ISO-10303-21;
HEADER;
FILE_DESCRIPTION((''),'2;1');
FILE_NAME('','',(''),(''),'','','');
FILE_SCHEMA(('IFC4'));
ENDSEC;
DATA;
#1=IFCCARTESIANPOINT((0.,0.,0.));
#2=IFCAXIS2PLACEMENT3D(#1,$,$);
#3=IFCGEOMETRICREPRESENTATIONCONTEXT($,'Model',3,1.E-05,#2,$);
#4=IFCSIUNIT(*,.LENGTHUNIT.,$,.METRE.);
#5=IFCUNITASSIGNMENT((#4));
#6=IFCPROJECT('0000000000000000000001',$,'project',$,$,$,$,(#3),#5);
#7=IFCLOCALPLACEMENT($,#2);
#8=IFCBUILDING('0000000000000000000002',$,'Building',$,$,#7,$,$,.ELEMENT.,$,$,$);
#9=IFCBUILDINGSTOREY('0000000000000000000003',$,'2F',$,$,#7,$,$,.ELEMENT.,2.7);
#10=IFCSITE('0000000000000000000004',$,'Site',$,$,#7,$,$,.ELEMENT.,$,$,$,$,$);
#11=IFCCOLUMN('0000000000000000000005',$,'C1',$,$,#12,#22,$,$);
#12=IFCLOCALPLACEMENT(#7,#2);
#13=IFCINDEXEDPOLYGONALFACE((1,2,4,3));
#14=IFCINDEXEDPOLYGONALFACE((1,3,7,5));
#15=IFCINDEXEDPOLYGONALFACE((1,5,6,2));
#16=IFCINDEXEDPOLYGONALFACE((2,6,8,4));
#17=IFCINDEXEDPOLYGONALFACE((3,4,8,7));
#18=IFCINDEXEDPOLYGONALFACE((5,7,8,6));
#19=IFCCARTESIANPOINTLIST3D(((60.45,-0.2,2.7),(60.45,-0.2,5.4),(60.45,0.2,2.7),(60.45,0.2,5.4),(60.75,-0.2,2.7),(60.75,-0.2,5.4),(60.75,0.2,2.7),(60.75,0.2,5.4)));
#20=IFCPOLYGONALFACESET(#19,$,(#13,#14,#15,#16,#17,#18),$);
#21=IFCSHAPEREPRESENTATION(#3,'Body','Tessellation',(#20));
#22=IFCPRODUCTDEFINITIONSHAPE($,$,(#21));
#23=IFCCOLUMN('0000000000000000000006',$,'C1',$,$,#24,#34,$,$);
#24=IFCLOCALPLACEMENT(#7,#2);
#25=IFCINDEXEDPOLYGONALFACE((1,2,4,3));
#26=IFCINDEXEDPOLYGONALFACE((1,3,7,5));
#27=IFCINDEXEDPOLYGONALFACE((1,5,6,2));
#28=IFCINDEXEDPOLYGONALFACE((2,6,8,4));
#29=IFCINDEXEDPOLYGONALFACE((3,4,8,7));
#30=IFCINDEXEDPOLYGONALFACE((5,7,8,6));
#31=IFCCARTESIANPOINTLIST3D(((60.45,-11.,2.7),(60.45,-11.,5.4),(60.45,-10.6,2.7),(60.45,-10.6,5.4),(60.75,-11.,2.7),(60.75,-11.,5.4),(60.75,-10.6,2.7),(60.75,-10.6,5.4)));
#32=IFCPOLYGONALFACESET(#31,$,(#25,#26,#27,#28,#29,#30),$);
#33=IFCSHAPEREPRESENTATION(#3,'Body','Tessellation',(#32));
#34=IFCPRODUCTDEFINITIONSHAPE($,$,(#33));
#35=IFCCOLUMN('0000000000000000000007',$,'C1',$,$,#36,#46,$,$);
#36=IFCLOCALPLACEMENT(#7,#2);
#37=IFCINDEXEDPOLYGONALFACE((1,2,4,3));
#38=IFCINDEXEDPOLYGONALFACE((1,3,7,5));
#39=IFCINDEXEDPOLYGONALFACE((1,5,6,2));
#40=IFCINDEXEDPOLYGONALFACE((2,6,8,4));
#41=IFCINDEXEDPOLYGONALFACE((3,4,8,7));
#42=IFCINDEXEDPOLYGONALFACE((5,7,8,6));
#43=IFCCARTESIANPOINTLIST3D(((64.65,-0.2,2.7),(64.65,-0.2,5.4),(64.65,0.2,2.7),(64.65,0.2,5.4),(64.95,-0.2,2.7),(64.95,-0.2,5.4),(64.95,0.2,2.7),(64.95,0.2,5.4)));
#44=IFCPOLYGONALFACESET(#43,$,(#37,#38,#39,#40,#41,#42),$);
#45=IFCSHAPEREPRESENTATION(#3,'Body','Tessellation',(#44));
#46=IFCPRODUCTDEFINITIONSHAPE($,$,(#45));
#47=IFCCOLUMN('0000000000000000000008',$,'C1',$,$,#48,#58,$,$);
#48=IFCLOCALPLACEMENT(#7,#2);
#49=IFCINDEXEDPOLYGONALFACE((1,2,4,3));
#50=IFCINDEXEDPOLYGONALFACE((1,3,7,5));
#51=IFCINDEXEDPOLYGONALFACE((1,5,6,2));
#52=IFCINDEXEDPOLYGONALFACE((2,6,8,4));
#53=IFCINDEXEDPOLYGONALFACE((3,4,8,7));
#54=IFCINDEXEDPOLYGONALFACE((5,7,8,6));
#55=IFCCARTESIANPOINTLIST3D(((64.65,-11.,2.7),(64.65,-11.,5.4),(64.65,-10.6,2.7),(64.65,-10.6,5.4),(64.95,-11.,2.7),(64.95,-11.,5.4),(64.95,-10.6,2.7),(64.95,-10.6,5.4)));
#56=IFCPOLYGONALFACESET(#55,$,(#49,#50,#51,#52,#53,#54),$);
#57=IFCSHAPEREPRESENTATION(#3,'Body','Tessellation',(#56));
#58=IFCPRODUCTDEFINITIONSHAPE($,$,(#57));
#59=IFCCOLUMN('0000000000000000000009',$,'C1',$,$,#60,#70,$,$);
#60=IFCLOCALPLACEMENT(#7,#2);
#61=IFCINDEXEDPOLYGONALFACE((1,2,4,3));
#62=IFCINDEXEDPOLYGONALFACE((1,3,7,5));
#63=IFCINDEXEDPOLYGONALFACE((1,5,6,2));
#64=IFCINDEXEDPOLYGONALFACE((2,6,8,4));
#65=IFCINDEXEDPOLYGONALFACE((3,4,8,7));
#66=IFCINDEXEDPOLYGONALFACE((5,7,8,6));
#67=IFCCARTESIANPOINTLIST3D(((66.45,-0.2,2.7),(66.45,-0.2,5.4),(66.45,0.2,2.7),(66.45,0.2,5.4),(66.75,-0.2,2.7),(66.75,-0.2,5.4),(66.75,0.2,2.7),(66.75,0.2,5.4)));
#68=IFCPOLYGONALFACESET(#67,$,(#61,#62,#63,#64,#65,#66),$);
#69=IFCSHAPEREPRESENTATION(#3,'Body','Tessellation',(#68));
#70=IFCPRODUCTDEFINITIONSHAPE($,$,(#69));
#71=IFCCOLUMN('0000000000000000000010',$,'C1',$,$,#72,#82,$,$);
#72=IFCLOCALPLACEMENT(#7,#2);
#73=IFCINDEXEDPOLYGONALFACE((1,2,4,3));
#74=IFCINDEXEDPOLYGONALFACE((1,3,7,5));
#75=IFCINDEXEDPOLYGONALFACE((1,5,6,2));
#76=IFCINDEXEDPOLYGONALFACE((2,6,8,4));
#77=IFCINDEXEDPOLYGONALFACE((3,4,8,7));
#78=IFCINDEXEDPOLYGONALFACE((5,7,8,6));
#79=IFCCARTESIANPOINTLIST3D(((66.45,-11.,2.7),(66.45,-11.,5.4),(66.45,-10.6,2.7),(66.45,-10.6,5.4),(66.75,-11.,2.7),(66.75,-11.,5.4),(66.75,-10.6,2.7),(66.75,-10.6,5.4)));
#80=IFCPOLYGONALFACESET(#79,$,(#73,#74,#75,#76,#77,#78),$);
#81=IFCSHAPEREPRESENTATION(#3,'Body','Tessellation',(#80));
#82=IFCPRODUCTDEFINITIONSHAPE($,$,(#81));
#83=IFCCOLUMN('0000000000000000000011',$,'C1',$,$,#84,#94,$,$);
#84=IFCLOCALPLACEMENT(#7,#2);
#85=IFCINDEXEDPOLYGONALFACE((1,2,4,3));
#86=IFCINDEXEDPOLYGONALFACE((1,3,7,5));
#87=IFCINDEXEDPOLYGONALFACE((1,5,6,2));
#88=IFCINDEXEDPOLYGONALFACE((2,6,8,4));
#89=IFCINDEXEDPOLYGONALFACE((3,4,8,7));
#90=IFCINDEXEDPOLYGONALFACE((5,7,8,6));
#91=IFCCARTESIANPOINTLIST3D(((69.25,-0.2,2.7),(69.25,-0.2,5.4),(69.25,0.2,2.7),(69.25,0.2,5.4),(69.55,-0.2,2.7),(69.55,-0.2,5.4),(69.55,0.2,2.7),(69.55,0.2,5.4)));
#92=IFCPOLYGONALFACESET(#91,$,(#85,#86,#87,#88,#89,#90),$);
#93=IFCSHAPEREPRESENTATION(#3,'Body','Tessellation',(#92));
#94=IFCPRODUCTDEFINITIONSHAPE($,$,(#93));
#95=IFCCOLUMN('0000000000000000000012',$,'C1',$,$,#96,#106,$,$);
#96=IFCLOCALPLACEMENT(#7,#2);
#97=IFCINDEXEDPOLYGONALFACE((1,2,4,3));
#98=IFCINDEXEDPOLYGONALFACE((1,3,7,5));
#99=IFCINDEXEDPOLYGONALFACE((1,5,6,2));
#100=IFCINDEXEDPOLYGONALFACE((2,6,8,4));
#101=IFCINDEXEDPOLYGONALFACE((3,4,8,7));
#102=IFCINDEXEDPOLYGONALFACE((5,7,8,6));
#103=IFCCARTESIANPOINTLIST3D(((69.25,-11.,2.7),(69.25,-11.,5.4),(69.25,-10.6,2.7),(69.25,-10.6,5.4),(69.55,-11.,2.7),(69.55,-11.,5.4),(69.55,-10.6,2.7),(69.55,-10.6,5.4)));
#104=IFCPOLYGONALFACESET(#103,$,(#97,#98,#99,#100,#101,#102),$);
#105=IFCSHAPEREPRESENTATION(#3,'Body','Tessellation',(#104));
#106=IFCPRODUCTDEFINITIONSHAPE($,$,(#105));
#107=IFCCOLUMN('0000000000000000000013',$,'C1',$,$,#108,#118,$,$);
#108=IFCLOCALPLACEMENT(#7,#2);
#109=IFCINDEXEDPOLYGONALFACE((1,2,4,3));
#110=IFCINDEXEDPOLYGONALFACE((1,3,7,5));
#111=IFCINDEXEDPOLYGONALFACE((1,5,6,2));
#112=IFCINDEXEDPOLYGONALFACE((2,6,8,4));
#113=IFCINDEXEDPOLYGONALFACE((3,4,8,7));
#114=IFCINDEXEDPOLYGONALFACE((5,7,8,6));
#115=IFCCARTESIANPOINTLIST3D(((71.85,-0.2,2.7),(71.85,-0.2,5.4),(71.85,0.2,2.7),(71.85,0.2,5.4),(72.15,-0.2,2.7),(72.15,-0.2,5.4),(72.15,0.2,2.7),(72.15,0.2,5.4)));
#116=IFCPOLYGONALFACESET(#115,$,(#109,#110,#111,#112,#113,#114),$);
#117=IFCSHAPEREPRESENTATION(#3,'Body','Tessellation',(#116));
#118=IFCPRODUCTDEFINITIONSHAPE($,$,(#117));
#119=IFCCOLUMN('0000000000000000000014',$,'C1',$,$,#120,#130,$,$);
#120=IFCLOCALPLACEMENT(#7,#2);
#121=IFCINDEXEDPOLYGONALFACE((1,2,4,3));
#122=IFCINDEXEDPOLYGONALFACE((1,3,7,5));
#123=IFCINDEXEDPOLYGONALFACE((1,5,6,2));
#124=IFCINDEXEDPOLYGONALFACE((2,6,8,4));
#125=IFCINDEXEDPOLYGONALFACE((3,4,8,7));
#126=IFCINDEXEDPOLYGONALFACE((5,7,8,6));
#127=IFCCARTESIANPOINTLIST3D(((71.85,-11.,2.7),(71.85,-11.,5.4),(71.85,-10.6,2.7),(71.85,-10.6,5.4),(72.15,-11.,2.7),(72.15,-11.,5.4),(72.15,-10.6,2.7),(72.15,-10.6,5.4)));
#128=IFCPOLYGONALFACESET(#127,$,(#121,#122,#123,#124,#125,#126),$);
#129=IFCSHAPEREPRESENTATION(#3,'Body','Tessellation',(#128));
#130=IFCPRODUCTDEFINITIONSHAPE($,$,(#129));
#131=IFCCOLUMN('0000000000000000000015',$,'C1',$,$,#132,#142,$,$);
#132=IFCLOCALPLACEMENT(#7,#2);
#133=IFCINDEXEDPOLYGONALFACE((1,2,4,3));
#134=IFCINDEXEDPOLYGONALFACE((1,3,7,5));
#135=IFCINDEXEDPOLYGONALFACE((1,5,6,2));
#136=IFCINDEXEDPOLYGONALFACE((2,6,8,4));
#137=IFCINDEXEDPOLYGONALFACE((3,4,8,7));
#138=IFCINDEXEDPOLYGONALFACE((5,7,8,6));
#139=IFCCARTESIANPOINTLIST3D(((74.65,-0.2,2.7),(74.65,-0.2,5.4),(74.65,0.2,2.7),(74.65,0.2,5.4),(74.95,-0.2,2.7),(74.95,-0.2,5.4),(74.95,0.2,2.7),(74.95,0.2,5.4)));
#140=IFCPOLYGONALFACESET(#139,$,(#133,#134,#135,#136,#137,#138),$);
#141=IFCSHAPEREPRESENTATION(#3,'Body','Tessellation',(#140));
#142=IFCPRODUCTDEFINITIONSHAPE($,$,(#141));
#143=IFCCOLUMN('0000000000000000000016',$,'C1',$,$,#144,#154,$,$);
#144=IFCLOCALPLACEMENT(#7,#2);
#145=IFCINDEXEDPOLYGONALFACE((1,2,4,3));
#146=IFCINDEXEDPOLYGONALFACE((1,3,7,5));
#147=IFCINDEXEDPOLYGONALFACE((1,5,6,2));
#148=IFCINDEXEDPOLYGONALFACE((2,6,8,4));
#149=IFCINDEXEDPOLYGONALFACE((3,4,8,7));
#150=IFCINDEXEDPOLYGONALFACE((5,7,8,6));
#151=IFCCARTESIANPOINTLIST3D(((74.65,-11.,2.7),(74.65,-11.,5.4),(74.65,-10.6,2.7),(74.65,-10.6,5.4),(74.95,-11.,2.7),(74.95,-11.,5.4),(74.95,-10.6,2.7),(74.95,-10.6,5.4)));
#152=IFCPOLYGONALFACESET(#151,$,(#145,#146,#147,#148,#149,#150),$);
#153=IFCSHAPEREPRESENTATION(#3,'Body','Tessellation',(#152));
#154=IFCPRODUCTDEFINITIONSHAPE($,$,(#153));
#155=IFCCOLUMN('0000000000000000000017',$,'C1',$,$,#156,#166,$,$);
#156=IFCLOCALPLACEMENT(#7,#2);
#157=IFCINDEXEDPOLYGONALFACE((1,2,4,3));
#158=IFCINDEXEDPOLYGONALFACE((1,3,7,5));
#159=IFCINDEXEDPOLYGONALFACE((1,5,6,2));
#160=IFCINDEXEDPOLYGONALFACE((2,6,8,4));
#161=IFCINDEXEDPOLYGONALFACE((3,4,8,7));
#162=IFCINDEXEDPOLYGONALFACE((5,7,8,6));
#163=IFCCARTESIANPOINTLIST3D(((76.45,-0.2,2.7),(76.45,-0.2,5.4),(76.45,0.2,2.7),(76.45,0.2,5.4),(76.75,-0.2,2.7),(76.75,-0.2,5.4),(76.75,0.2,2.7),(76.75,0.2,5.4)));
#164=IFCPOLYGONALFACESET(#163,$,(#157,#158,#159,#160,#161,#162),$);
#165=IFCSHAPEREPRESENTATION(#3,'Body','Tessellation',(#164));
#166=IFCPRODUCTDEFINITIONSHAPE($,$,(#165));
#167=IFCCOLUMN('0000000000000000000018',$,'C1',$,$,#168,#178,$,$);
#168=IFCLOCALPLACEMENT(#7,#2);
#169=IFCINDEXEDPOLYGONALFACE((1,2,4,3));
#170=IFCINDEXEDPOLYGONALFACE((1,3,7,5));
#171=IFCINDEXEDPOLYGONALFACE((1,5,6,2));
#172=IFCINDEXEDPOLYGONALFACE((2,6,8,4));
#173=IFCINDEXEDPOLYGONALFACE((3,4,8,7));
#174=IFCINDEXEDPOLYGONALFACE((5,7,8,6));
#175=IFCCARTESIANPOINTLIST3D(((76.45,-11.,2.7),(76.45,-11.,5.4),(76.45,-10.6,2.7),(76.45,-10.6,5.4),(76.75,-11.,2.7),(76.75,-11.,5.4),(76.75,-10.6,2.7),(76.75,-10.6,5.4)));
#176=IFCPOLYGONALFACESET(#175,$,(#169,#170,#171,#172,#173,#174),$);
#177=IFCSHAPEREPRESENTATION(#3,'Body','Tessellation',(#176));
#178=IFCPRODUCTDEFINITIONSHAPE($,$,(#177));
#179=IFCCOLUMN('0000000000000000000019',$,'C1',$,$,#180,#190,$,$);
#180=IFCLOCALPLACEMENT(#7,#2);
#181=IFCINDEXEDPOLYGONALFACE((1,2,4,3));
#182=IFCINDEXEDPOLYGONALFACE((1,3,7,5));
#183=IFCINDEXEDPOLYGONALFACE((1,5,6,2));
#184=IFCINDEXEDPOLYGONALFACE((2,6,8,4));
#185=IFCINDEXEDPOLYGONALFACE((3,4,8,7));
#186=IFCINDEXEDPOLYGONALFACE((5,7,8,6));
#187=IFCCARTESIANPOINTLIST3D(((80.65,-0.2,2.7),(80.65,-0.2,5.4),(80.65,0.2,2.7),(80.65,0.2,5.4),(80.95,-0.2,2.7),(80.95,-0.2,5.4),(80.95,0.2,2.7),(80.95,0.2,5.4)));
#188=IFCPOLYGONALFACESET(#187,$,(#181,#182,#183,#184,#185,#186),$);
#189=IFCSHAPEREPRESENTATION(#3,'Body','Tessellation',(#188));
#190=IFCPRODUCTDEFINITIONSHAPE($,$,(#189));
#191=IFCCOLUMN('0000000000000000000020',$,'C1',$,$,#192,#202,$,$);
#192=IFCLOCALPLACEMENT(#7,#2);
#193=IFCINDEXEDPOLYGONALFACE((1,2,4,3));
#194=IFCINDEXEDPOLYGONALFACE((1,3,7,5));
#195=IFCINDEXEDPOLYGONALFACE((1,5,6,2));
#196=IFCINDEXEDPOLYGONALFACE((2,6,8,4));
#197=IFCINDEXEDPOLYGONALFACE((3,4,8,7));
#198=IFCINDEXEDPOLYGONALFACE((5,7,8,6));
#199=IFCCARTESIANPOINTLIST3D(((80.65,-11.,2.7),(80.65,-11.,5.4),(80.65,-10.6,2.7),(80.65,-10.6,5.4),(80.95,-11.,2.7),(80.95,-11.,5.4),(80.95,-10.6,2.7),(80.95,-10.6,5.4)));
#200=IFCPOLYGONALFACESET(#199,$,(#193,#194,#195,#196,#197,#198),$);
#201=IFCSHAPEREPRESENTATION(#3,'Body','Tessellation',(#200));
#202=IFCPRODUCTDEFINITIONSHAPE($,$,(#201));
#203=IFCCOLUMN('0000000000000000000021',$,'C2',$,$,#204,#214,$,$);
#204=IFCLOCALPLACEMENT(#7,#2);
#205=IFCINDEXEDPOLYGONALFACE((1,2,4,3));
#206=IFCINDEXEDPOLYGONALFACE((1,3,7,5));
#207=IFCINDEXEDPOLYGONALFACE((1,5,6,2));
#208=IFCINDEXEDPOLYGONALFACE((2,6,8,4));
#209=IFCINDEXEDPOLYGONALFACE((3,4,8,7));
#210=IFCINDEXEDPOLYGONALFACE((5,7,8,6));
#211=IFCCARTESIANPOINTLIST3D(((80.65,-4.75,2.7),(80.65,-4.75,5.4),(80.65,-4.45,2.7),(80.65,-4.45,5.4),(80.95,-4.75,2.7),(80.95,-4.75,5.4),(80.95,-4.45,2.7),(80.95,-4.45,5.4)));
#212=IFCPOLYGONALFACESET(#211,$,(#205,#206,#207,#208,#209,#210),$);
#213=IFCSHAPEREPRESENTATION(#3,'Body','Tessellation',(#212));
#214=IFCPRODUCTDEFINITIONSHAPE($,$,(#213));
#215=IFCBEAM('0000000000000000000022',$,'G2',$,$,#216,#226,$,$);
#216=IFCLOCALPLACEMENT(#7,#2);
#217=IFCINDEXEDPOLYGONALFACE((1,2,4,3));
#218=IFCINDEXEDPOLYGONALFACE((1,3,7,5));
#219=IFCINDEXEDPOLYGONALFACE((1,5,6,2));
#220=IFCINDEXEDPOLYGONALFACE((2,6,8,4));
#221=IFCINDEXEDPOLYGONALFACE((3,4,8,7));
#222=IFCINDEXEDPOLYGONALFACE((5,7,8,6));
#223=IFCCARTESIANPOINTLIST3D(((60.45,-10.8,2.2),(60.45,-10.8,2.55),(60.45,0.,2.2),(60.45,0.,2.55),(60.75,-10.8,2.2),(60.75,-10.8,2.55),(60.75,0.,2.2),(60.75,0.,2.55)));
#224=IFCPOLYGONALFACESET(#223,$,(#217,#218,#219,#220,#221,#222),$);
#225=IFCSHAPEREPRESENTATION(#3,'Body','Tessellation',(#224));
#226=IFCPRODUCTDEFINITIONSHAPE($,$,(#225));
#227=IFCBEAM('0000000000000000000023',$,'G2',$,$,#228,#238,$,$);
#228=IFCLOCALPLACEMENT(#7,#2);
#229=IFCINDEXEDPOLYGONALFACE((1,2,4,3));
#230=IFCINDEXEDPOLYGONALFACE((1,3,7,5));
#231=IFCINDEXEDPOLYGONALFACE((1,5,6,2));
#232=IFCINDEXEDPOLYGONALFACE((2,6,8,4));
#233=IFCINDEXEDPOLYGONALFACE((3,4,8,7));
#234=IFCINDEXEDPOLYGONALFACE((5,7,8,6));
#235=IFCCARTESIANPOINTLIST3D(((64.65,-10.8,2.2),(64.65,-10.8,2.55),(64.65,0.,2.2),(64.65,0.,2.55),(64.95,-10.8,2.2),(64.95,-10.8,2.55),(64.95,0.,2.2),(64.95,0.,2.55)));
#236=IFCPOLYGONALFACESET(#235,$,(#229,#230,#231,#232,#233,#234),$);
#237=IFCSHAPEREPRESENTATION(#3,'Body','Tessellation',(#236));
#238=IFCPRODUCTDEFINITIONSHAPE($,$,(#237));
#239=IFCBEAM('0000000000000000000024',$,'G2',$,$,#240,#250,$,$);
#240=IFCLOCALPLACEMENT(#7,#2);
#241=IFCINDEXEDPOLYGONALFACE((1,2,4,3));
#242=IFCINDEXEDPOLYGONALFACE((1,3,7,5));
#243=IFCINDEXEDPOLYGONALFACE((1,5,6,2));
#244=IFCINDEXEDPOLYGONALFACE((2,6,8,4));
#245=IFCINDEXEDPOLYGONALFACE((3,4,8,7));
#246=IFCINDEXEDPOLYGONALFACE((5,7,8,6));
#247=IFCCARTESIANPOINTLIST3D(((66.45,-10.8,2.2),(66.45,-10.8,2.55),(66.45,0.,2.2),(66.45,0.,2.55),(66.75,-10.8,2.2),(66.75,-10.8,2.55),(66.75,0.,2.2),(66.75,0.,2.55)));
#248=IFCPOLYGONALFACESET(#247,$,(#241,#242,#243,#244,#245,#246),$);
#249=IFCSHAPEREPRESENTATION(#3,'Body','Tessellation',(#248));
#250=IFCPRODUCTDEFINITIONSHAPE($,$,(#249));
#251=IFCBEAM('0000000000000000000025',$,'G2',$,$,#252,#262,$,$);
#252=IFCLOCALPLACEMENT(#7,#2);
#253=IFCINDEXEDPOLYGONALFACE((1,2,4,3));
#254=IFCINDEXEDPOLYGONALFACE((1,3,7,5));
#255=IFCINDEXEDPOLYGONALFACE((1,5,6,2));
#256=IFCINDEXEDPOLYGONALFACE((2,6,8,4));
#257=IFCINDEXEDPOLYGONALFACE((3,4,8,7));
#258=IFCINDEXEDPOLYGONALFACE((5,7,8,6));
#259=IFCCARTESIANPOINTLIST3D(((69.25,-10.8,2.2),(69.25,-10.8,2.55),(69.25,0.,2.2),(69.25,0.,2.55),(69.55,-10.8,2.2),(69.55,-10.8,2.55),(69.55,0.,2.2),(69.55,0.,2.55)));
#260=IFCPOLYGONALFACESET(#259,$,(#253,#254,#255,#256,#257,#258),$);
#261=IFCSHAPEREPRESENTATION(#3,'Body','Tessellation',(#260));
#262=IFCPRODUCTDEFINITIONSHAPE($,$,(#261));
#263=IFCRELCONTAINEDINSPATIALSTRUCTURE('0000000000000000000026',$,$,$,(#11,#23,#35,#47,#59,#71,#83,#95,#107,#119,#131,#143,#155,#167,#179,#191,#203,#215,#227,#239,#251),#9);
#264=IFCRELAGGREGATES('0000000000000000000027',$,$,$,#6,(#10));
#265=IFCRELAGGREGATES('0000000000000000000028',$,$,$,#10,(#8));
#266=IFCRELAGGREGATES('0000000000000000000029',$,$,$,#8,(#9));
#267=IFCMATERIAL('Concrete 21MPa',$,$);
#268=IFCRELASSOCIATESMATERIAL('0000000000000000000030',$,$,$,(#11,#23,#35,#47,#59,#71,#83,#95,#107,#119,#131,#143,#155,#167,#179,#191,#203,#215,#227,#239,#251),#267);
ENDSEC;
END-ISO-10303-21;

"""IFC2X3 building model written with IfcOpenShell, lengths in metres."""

from ifc_helpers import new_model, si_unit, frame, origin, origin_2d, place, context, project, spatial, rectangle, extrude, material, element, save


model = new_model("IFC2X3")

# Units and contexts
model_context = context("Model", 3, precision=1e-05, world=origin())
ifc_project = project(units=[si_unit("LENGTHUNIT", "METRE")], contexts=[model_context])

# Site, building, storey
placement = place(None, origin())
site = spatial("IfcSite", under=ifc_project, at=placement, Name="Site", CompositionType="ELEMENT")
building = spatial("IfcBuilding", under=site, at=placement, Name="Building", CompositionType="ELEMENT")
storey = spatial("IfcBuildingStorey", under=building, at=placement, Name="2F", CompositionType="ELEMENT", Elevation=2.7)

# Columns
ifc_material = material(Name="Concrete 21MPa")
for number, where, name in (
    (1, (60.6, 0.0, 2.7), "C1"),
    (2, (60.6, -10.8, 2.7), "C1"),
    (3, (64.8, 0.0, 2.7), "C1"),
    (4, (64.8, -10.8, 2.7), "C1"),
    (5, (66.6, 0.0, 2.7), "C1"),
    (6, (66.6, -10.8, 2.7), "C1"),
    (7, (69.4, 0.0, 2.7), "C1"),
    (8, (69.4, -10.8, 2.7), "C1"),
    (9, (72.0, 0.0, 2.7), "C1"),
    (10, (72.0, -10.8, 2.7), "C1"),
    (11, (74.8, 0.0, 2.7), "C1"),
    (12, (74.8, -10.8, 2.7), "C1"),
    (13, (76.6, 0.0, 2.7), "C1"),
    (14, (76.6, -10.8, 2.7), "C1"),
    (15, (80.8, 0.0, 2.7), "C1"),
    (16, (80.8, -10.8, 2.7), "C1"),
):
    element("IfcColumn", number, at=place(None, frame(where)), inside=storey, material=ifc_material, Name=name, context=model_context, shape_type="SweptSolid", body=[
        extrude(rectangle(XDim=0.3, YDim=0.4, at=origin_2d()), origin(), (0.0, 0.0, 1.0), 2.7),
    ])
column_placement = place(None, frame((80.8, -4.6, 2.7)))
element("IfcColumn", 17, at=column_placement, inside=storey, material=ifc_material, Name="C2", context=model_context, shape_type="SweptSolid", body=[
    extrude(rectangle(XDim=0.3, YDim=0.3, at=origin_2d()), origin(), (0.0, 0.0, 1.0), 2.7),
])

# Beams
for number, where, name in (
    (18, (60.6, -5.4, 2.2), "G2"),
    (19, (64.8, -5.4, 2.2), "G2"),
    (20, (66.6, -5.4, 2.2), "G2"),
    (21, (69.4, -5.4, 2.2), "G2"),
):
    element("IfcBeam", number, at=place(None, frame(where)), inside=storey, material=ifc_material, Name=name, context=model_context, shape_type="SweptSolid", body=[
        extrude(rectangle(XDim=0.3, YDim=10.8, at=origin_2d()), origin(), (0.0, 0.0, 1.0), 0.35),
    ])

save(model, "model.ifc")
